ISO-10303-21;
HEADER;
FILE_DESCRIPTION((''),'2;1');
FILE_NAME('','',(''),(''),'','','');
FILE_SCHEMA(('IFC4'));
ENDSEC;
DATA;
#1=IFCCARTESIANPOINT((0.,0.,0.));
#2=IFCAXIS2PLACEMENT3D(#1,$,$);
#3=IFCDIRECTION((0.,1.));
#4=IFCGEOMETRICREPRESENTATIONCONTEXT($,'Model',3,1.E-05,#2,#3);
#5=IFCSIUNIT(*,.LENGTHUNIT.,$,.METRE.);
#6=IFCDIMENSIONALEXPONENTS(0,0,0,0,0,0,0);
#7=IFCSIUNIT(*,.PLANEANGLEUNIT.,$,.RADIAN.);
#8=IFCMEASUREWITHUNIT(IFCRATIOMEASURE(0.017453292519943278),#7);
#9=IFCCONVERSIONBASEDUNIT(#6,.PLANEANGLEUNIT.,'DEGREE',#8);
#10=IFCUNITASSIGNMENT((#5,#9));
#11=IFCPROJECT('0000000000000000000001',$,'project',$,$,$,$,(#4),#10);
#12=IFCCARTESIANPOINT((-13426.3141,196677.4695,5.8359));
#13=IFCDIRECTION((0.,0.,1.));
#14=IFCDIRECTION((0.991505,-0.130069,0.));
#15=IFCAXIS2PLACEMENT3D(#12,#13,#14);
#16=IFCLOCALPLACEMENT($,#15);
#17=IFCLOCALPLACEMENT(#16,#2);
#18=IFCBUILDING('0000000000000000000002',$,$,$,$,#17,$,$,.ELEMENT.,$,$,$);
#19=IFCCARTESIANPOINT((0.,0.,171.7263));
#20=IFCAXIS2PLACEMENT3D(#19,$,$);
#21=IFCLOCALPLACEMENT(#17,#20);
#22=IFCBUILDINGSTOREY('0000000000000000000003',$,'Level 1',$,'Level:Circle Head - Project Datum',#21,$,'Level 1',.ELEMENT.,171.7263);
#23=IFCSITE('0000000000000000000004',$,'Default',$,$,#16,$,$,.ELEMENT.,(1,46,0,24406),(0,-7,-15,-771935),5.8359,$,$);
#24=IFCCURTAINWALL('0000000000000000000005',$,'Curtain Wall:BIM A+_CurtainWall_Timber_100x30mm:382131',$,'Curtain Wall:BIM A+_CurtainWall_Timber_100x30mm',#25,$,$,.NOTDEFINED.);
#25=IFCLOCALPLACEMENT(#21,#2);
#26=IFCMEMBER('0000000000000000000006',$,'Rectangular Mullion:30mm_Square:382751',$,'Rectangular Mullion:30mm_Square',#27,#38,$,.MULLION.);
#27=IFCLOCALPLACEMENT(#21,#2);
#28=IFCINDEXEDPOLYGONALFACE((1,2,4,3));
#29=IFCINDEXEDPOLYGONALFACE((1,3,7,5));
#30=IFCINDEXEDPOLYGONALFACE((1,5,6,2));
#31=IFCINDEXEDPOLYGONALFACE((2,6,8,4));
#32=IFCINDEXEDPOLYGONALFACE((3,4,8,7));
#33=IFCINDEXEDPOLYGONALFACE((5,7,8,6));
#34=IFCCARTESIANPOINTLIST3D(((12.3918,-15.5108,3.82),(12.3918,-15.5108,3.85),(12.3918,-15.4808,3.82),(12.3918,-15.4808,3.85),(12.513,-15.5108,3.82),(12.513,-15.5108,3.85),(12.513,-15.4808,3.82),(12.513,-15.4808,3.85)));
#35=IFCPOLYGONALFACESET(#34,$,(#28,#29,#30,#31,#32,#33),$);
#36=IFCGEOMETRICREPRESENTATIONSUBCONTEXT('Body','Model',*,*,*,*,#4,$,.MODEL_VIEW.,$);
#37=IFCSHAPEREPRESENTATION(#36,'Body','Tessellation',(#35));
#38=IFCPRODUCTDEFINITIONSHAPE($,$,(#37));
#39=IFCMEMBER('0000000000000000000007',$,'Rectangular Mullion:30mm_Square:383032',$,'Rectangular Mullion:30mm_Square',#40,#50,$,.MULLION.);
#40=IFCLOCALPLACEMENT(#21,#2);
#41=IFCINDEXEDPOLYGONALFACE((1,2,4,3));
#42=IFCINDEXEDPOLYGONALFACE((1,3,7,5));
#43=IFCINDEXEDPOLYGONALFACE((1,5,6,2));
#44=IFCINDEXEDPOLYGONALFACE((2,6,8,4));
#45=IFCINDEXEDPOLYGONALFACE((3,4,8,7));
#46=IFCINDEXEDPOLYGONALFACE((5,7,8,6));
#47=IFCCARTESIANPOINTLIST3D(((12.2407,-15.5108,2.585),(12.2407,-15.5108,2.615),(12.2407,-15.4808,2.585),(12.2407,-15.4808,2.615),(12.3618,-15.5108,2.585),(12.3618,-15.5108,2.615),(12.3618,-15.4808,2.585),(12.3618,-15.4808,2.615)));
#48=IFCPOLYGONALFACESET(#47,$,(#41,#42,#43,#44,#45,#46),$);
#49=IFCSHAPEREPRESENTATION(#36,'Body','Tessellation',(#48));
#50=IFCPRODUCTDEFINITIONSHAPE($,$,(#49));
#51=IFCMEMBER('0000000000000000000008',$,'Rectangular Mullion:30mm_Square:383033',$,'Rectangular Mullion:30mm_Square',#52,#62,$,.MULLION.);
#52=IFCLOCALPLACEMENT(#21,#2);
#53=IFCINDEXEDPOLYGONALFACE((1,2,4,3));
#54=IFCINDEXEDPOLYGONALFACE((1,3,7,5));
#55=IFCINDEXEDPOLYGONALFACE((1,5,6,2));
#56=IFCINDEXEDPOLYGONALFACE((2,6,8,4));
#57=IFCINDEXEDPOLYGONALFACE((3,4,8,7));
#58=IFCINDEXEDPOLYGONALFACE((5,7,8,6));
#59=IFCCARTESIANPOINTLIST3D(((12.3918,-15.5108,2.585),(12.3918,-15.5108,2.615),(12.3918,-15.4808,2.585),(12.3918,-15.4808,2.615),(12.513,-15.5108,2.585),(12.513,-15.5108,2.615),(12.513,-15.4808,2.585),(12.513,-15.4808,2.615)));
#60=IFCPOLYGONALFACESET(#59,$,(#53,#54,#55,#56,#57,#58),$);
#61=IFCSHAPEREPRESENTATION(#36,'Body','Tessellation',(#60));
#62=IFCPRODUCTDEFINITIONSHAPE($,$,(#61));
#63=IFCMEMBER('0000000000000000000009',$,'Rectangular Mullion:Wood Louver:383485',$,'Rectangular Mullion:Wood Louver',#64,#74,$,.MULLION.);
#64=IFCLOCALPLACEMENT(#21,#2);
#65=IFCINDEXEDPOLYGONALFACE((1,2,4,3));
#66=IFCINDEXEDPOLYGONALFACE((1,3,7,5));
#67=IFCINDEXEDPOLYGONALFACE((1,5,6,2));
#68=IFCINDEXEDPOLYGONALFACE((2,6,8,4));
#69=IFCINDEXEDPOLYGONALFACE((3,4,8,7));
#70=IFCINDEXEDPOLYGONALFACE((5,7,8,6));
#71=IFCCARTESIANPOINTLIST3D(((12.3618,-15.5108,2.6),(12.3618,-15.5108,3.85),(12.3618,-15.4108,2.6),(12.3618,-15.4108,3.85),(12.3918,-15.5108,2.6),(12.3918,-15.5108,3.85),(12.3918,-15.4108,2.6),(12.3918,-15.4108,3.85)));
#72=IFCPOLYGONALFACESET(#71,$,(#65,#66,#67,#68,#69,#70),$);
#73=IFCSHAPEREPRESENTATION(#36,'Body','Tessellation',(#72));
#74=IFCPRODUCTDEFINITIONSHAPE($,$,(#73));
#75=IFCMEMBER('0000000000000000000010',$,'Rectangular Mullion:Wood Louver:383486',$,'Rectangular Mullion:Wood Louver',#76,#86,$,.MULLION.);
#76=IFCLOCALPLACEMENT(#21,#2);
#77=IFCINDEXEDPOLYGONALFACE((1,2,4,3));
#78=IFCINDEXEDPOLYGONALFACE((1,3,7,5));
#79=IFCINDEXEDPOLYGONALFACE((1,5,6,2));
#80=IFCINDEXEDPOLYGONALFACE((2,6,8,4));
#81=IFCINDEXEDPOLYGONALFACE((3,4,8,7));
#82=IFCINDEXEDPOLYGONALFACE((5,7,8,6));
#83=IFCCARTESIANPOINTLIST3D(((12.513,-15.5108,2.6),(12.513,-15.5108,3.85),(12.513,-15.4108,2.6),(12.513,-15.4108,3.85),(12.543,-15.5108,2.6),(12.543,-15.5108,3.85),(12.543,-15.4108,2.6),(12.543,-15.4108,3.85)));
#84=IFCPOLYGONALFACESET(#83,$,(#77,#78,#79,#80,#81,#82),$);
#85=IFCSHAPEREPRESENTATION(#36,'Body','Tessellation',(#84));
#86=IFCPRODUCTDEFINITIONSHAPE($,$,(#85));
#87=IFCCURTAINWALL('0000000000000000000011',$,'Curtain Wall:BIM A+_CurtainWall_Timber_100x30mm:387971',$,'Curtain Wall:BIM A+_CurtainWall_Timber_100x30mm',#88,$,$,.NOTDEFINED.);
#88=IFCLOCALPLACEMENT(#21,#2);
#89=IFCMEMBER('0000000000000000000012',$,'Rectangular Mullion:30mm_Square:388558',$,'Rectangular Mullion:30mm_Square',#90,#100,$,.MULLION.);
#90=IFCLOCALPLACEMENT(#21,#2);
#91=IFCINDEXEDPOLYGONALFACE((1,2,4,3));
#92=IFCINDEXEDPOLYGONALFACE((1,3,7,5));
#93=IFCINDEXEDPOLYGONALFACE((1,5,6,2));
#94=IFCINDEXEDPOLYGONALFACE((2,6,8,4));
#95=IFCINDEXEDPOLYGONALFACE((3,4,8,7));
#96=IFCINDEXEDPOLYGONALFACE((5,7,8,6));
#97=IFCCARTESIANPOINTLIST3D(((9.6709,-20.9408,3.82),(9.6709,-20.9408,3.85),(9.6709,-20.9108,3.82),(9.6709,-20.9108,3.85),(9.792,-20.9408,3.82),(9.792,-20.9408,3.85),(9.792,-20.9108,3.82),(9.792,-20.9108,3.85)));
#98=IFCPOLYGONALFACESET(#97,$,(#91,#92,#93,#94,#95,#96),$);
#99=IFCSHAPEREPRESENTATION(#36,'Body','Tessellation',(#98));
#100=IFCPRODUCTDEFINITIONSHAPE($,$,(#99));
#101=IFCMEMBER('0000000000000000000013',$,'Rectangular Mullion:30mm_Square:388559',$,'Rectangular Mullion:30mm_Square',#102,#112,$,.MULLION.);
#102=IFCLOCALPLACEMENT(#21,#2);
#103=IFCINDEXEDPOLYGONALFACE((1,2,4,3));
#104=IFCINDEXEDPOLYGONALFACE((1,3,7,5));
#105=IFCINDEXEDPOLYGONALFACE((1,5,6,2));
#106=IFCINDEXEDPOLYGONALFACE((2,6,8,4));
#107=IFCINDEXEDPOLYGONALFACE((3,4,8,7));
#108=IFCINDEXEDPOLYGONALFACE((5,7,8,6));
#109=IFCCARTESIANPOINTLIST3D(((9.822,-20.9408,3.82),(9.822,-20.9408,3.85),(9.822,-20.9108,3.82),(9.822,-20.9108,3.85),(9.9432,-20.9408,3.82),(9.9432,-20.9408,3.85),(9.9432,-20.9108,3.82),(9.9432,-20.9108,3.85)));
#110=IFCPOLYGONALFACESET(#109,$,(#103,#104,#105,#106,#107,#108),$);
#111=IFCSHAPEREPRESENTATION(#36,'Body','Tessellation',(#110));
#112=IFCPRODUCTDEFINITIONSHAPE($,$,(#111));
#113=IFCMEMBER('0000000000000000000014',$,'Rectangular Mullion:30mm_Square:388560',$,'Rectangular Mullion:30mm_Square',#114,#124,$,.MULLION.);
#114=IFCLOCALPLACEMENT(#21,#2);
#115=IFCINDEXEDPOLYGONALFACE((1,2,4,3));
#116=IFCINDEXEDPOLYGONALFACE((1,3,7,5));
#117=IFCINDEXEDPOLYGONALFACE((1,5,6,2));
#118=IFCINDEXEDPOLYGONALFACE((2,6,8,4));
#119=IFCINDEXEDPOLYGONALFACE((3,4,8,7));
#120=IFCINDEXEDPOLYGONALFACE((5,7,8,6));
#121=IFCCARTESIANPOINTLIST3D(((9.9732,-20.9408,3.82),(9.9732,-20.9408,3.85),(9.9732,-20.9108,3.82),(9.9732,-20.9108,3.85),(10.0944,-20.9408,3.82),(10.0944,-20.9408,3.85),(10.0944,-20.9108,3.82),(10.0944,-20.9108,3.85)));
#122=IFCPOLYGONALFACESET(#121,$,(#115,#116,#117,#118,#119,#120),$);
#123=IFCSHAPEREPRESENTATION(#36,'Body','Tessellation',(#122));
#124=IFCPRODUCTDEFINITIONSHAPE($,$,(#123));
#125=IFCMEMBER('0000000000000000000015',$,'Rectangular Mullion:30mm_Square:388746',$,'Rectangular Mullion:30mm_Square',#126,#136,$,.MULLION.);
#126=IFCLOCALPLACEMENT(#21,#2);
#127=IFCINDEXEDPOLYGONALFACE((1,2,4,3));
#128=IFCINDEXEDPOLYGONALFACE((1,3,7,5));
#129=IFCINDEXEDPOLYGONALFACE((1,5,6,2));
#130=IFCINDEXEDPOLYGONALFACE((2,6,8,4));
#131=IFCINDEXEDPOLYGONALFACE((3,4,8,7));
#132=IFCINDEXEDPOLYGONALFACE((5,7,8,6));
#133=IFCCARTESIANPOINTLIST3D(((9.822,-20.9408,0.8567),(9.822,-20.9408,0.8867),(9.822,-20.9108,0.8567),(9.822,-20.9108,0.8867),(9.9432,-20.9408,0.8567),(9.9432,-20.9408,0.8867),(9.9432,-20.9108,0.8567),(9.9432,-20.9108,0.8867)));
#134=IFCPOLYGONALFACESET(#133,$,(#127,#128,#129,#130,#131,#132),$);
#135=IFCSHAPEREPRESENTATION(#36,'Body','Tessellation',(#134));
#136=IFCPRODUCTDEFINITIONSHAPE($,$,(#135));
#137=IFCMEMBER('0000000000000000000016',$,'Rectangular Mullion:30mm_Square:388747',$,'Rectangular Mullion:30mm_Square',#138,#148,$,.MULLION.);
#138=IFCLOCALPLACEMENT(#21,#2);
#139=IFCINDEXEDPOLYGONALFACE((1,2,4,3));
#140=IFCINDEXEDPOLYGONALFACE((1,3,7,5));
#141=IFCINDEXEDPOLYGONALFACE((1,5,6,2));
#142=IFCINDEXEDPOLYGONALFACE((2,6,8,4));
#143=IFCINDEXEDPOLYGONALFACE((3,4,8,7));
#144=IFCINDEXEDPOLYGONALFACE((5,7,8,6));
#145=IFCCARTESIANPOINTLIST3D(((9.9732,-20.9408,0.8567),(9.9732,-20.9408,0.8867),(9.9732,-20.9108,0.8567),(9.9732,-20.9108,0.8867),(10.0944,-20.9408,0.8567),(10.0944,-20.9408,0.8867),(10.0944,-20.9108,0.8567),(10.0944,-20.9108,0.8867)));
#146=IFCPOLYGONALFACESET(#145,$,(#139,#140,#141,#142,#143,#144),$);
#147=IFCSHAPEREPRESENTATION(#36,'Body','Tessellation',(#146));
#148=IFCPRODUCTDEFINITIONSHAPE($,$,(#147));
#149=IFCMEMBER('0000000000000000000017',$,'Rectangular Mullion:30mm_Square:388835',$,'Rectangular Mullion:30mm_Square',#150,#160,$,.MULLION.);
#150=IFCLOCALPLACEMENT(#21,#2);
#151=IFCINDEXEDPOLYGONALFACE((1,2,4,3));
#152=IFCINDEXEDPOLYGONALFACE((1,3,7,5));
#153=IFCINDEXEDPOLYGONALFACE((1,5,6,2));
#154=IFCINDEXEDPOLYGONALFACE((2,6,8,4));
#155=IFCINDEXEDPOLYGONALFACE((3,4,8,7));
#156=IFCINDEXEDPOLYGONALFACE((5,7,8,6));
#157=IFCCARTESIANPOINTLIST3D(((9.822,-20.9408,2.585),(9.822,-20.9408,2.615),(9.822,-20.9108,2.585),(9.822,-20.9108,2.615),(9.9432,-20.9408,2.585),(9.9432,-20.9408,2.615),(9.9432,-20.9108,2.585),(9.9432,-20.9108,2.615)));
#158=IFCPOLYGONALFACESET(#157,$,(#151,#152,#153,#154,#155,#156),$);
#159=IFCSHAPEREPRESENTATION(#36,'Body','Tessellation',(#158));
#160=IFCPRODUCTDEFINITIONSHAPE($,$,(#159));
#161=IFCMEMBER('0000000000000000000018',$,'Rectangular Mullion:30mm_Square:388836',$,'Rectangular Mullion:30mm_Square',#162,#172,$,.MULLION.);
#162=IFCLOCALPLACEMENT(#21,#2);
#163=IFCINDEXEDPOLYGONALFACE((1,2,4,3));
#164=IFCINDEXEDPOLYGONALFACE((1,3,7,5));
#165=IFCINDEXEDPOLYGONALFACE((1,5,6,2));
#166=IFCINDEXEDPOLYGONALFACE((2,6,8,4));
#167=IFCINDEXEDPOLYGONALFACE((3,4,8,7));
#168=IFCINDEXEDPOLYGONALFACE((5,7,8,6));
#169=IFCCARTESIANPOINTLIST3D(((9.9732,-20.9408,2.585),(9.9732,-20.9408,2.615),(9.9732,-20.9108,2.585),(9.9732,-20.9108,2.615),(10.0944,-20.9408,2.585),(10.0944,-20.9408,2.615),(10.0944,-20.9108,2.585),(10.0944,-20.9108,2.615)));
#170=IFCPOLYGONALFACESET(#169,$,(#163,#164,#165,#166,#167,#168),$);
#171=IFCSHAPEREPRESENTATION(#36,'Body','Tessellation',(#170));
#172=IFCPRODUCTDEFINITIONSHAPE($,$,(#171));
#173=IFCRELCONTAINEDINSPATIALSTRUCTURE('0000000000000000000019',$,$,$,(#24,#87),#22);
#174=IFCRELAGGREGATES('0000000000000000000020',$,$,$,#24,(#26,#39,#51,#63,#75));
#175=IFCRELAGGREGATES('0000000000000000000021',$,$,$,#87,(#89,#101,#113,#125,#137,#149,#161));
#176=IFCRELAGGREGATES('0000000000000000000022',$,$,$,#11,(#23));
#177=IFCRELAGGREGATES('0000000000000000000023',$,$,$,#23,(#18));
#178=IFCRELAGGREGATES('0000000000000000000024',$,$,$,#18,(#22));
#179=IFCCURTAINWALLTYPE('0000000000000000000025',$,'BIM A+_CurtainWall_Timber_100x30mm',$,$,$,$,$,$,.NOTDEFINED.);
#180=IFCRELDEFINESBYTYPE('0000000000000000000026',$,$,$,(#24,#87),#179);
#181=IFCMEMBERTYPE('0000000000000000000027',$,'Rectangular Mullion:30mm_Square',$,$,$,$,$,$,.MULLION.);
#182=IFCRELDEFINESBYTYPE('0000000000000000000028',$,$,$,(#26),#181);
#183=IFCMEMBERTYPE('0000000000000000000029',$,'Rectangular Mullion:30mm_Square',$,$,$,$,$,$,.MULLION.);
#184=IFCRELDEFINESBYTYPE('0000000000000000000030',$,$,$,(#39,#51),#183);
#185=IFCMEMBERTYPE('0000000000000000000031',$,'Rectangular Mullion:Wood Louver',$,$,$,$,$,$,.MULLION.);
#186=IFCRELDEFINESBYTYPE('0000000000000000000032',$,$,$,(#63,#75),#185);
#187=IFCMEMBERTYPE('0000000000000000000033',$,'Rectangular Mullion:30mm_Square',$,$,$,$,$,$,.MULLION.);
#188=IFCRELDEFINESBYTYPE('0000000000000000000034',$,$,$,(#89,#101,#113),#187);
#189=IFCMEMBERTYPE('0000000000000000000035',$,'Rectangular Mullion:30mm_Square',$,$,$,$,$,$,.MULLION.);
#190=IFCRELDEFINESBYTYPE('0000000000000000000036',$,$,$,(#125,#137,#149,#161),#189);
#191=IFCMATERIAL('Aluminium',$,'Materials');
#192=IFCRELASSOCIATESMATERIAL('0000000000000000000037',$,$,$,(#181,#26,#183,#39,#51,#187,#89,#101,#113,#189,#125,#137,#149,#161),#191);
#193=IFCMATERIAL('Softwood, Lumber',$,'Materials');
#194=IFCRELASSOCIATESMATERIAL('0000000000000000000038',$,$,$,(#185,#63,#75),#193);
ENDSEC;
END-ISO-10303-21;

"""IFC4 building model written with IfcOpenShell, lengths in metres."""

from ifc_helpers import new_model, entity, si_unit, converted_unit, direction, frame, origin, place, context, subcontext, project, spatial, indexed_curve, outline, extrude, source, transform, mapped, material, type_object, type_shapes, element, aggregate, save


model = new_model("IFC4")

# Units and contexts
model_context = context("Model", 3, precision=1e-05, world=origin(), true_north=direction((0.0, 1.0)))
body_context = subcontext(model_context, "Body", "Model", "MODEL_VIEW")
ifc_project = project(units=[si_unit("LENGTHUNIT", "METRE"), converted_unit("PLANEANGLEUNIT", "DEGREE", entity("IfcRatioMeasure", 0.017453292519943278), si_unit("PLANEANGLEUNIT", "RADIAN"), dimensions=[0, 0, 0, 0, 0, 0, 0])], contexts=[model_context])

# Site, building, storey
site_placement = place(None, frame((-13426.3141, 196677.4695, 5.8359), z_axis=(0.0, 0.0, 1.0), x_axis=(0.991505, -0.130069, 0.0)))
site = spatial("IfcSite", under=ifc_project, at=site_placement, Name="Default", CompositionType="ELEMENT", RefLatitude=(1, 46, 0, 24406), RefLongitude=(0, -7, -15, -771935), RefElevation=5.8359)
building_placement = place(site_placement, origin())
building = spatial("IfcBuilding", under=site, at=building_placement, CompositionType="ELEMENT")
storey_placement = place(building_placement, frame((0.0, 0.0, 171.7263)))
storey = spatial("IfcBuildingStorey", under=building, at=storey_placement, Name="Level 1", ObjectType="Level:Circle Head - Project Datum", LongName="Level 1", CompositionType="ELEMENT", Elevation=171.7263)

# Curtain walls, members
ifc_material_1 = material(Name="Aluminium", Category="Materials")
curtain_wall_type_1 = type_object("IfcCurtainWallType", Name="BIM A+_CurtainWall_Timber_100x30mm", PredefinedType="NOTDEFINED")
curtain_wall_1_placement = place(storey_placement, frame((0.0, 0.0, -171.7263)))
curtain_wall_1 = element("IfcCurtainWall", 1, at=curtain_wall_1_placement, inside=storey, type_object=curtain_wall_type_1, Name="Curtain Wall:BIM A+_CurtainWall_Timber_100x30mm:382131", ObjectType="Curtain Wall:BIM A+_CurtainWall_Timber_100x30mm", PredefinedType="NOTDEFINED")
member_type_1 = type_object("IfcMemberType", Name="Rectangular Mullion:30mm_Square", PredefinedType="MULLION", material=ifc_material_1)
shared_shape_1 = source(origin(), body_context, "Body", "SweptSolid", [
    extrude(outline(indexed_curve([(-0.015, -0.015), (0.015, -0.015), (0.015, 0.015), (-0.015, 0.015), (-0.015, -0.015)], self_intersect=False)), frame((-0.015, 0.0, -0.1212), z_axis=(0.0, 0.0, 1.0), x_axis=(0.0, -1.0, 0.0)), (0.0, 0.0, 1.0), 0.1212),
])
type_shapes(member_type_1, [shared_shape_1])
member_1_placement = place(curtain_wall_1_placement, frame((12.513, -15.4958, 175.5763), z_axis=(1.0, 0.0, 0.0), x_axis=(0.0, 0.0, 1.0)))
member_1 = element("IfcMember", 2, at=member_1_placement, type_object=member_type_1, material=ifc_material_1, Name="Rectangular Mullion:30mm_Square:382751", ObjectType="Rectangular Mullion:30mm_Square", PredefinedType="MULLION", context=body_context, shape_type="MappedRepresentation", body=[
    mapped(shared_shape_1, transform((0.0, 0.0, 0.0), scale=1.0)),
])
member_type_2 = type_object("IfcMemberType", Name="Rectangular Mullion:30mm_Square", PredefinedType="MULLION", material=ifc_material_1)
shared_shape_2 = source(origin(), body_context, "Body", "SweptSolid", [
    extrude(outline(indexed_curve([(-0.015, -0.015), (0.015, -0.015), (0.015, 0.015), (-0.015, 0.015), (-0.015, -0.015)], self_intersect=False)), frame((0.0, 0.0, -0.1212), z_axis=(0.0, 0.0, 1.0), x_axis=(0.0, -1.0, 0.0)), (0.0, 0.0, 1.0), 0.1212),
])
type_shapes(member_type_2, [shared_shape_2])
member_2_placement = place(curtain_wall_1_placement, frame((12.3618, -15.4958, 174.3263), z_axis=(1.0, 0.0, 0.0), x_axis=(0.0, 0.0, 1.0)))
member_2 = element("IfcMember", 3, at=member_2_placement, type_object=member_type_2, material=ifc_material_1, Name="Rectangular Mullion:30mm_Square:383032", ObjectType="Rectangular Mullion:30mm_Square", PredefinedType="MULLION", context=body_context, shape_type="MappedRepresentation", body=[
    mapped(shared_shape_2, transform((0.0, 0.0, 0.0), scale=1.0)),
])
member_3_placement = place(curtain_wall_1_placement, frame((12.513, -15.4958, 174.3263), z_axis=(1.0, 0.0, 0.0), x_axis=(0.0, 0.0, 1.0)))
member_3 = element("IfcMember", 4, at=member_3_placement, type_object=member_type_2, material=ifc_material_1, Name="Rectangular Mullion:30mm_Square:383033", ObjectType="Rectangular Mullion:30mm_Square", PredefinedType="MULLION", context=body_context, shape_type="MappedRepresentation", body=[
    mapped(shared_shape_2, transform((0.0, 0.0, 0.0), scale=1.0)),
])
ifc_material_2 = material(Name="Softwood, Lumber", Category="Materials")
member_type_3 = type_object("IfcMemberType", Name="Rectangular Mullion:Wood Louver", PredefinedType="MULLION", material=ifc_material_2)
shared_shape_3 = source(origin(), body_context, "Body", "SweptSolid", [
    extrude(outline(indexed_curve([(-0.05, -0.015), (0.05, -0.015), (0.05, 0.015), (-0.05, 0.015), (-0.05, -0.015)], self_intersect=False)), frame((0.0, -0.035, -1.25), z_axis=(0.0, 0.0, 1.0), x_axis=(0.0, -1.0, 0.0)), (0.0, 0.0, 1.0), 1.25),
])
type_shapes(member_type_3, [shared_shape_3])
member_4_placement = place(curtain_wall_1_placement, frame((12.3768, -15.4958, 174.3263), z_axis=(0.0, 0.0, -1.0), x_axis=(1.0, 0.0, 0.0)))
member_4 = element("IfcMember", 5, at=member_4_placement, type_object=member_type_3, material=ifc_material_2, Name="Rectangular Mullion:Wood Louver:383485", ObjectType="Rectangular Mullion:Wood Louver", PredefinedType="MULLION", context=body_context, shape_type="MappedRepresentation", body=[
    mapped(shared_shape_3, transform((0.0, 0.0, 0.0), scale=1.0)),
])
member_5_placement = place(curtain_wall_1_placement, frame((12.528, -15.4958, 174.3263), z_axis=(0.0, 0.0, -1.0), x_axis=(1.0, 0.0, 0.0)))
member_5 = element("IfcMember", 6, at=member_5_placement, type_object=member_type_3, material=ifc_material_2, Name="Rectangular Mullion:Wood Louver:383486", ObjectType="Rectangular Mullion:Wood Louver", PredefinedType="MULLION", context=body_context, shape_type="MappedRepresentation", body=[
    mapped(shared_shape_3, transform((0.0, 0.0, 0.0), scale=1.0)),
])
curtain_wall_2_placement = place(storey_placement, frame((0.0, 0.0, -171.7263)))
curtain_wall_2 = element("IfcCurtainWall", 7, at=curtain_wall_2_placement, inside=storey, type_object=curtain_wall_type_1, Name="Curtain Wall:BIM A+_CurtainWall_Timber_100x30mm:387971", ObjectType="Curtain Wall:BIM A+_CurtainWall_Timber_100x30mm", PredefinedType="NOTDEFINED")
member_type_4 = type_object("IfcMemberType", Name="Rectangular Mullion:30mm_Square", PredefinedType="MULLION", material=ifc_material_1)
shared_shape_4 = source(origin(), body_context, "Body", "SweptSolid", [
    extrude(outline(indexed_curve([(-0.015, -0.015), (0.015, -0.015), (0.015, 0.015), (-0.015, 0.015), (-0.015, -0.015)], self_intersect=False)), frame((-0.015, 0.0, -0.1212), z_axis=(0.0, 0.0, 1.0), x_axis=(0.0, -1.0, 0.0)), (0.0, 0.0, 1.0), 0.1212),
])
type_shapes(member_type_4, [shared_shape_4])
member_6_placement = place(curtain_wall_2_placement, frame((9.792, -20.9258, 175.5763), z_axis=(1.0, 0.0, 0.0), x_axis=(0.0, 0.0, 1.0)))
member_6 = element("IfcMember", 8, at=member_6_placement, type_object=member_type_4, material=ifc_material_1, Name="Rectangular Mullion:30mm_Square:388558", ObjectType="Rectangular Mullion:30mm_Square", PredefinedType="MULLION", context=body_context, shape_type="MappedRepresentation", body=[
    mapped(shared_shape_4, transform((0.0, 0.0, 0.0), scale=1.0)),
])
member_7_placement = place(curtain_wall_2_placement, frame((9.9432, -20.9258, 175.5763), z_axis=(1.0, 0.0, 0.0), x_axis=(0.0, 0.0, 1.0)))
member_7 = element("IfcMember", 9, at=member_7_placement, type_object=member_type_4, material=ifc_material_1, Name="Rectangular Mullion:30mm_Square:388559", ObjectType="Rectangular Mullion:30mm_Square", PredefinedType="MULLION", context=body_context, shape_type="MappedRepresentation", body=[
    mapped(shared_shape_4, transform((0.0, 0.0, 0.0), scale=1.0)),
])
member_8_placement = place(curtain_wall_2_placement, frame((10.0944, -20.9258, 175.5763), z_axis=(1.0, 0.0, 0.0), x_axis=(0.0, 0.0, 1.0)))
member_8 = element("IfcMember", 10, at=member_8_placement, type_object=member_type_4, material=ifc_material_1, Name="Rectangular Mullion:30mm_Square:388560", ObjectType="Rectangular Mullion:30mm_Square", PredefinedType="MULLION", context=body_context, shape_type="MappedRepresentation", body=[
    mapped(shared_shape_4, transform((0.0, 0.0, 0.0), scale=1.0)),
])
member_type_5 = type_object("IfcMemberType", Name="Rectangular Mullion:30mm_Square", PredefinedType="MULLION", material=ifc_material_1)
shared_shape_5 = source(origin(), body_context, "Body", "SweptSolid", [
    extrude(outline(indexed_curve([(-0.015, -0.015), (0.015, -0.015), (0.015, 0.015), (-0.015, 0.015), (-0.015, -0.015)], self_intersect=False)), frame((0.0, 0.0, -0.1212), z_axis=(0.0, 0.0, 1.0), x_axis=(0.0, -1.0, 0.0)), (0.0, 0.0, 1.0), 0.1212),
])
type_shapes(member_type_5, [shared_shape_5])
member_9_placement = place(curtain_wall_2_placement, frame((9.9432, -20.9258, 172.598), z_axis=(1.0, 0.0, 0.0), x_axis=(0.0, 0.0, 1.0)))
member_9 = element("IfcMember", 11, at=member_9_placement, type_object=member_type_5, material=ifc_material_1, Name="Rectangular Mullion:30mm_Square:388746", ObjectType="Rectangular Mullion:30mm_Square", PredefinedType="MULLION", context=body_context, shape_type="MappedRepresentation", body=[
    mapped(shared_shape_5, transform((0.0, 0.0, 0.0), scale=1.0)),
])
member_10_placement = place(curtain_wall_2_placement, frame((10.0944, -20.9258, 172.598), z_axis=(1.0, 0.0, 0.0), x_axis=(0.0, 0.0, 1.0)))
member_10 = element("IfcMember", 12, at=member_10_placement, type_object=member_type_5, material=ifc_material_1, Name="Rectangular Mullion:30mm_Square:388747", ObjectType="Rectangular Mullion:30mm_Square", PredefinedType="MULLION", context=body_context, shape_type="MappedRepresentation", body=[
    mapped(shared_shape_5, transform((0.0, 0.0, 0.0), scale=1.0)),
])
member_11_placement = place(curtain_wall_2_placement, frame((9.9432, -20.9258, 174.3263), z_axis=(1.0, 0.0, 0.0), x_axis=(0.0, 0.0, 1.0)))
member_11 = element("IfcMember", 13, at=member_11_placement, type_object=member_type_5, material=ifc_material_1, Name="Rectangular Mullion:30mm_Square:388835", ObjectType="Rectangular Mullion:30mm_Square", PredefinedType="MULLION", context=body_context, shape_type="MappedRepresentation", body=[
    mapped(shared_shape_5, transform((0.0, 0.0, 0.0), scale=1.0)),
])
member_12_placement = place(curtain_wall_2_placement, frame((10.0944, -20.9258, 174.3263), z_axis=(1.0, 0.0, 0.0), x_axis=(0.0, 0.0, 1.0)))
member_12 = element("IfcMember", 14, at=member_12_placement, type_object=member_type_5, material=ifc_material_1, Name="Rectangular Mullion:30mm_Square:388836", ObjectType="Rectangular Mullion:30mm_Square", PredefinedType="MULLION", context=body_context, shape_type="MappedRepresentation", body=[
    mapped(shared_shape_5, transform((0.0, 0.0, 0.0), scale=1.0)),
])

aggregate(curtain_wall_1, [member_1, member_2, member_3, member_4, member_5])
aggregate(curtain_wall_2, [member_6, member_7, member_8, member_9, member_10, member_11, member_12])

save(model, "model.ifc")
